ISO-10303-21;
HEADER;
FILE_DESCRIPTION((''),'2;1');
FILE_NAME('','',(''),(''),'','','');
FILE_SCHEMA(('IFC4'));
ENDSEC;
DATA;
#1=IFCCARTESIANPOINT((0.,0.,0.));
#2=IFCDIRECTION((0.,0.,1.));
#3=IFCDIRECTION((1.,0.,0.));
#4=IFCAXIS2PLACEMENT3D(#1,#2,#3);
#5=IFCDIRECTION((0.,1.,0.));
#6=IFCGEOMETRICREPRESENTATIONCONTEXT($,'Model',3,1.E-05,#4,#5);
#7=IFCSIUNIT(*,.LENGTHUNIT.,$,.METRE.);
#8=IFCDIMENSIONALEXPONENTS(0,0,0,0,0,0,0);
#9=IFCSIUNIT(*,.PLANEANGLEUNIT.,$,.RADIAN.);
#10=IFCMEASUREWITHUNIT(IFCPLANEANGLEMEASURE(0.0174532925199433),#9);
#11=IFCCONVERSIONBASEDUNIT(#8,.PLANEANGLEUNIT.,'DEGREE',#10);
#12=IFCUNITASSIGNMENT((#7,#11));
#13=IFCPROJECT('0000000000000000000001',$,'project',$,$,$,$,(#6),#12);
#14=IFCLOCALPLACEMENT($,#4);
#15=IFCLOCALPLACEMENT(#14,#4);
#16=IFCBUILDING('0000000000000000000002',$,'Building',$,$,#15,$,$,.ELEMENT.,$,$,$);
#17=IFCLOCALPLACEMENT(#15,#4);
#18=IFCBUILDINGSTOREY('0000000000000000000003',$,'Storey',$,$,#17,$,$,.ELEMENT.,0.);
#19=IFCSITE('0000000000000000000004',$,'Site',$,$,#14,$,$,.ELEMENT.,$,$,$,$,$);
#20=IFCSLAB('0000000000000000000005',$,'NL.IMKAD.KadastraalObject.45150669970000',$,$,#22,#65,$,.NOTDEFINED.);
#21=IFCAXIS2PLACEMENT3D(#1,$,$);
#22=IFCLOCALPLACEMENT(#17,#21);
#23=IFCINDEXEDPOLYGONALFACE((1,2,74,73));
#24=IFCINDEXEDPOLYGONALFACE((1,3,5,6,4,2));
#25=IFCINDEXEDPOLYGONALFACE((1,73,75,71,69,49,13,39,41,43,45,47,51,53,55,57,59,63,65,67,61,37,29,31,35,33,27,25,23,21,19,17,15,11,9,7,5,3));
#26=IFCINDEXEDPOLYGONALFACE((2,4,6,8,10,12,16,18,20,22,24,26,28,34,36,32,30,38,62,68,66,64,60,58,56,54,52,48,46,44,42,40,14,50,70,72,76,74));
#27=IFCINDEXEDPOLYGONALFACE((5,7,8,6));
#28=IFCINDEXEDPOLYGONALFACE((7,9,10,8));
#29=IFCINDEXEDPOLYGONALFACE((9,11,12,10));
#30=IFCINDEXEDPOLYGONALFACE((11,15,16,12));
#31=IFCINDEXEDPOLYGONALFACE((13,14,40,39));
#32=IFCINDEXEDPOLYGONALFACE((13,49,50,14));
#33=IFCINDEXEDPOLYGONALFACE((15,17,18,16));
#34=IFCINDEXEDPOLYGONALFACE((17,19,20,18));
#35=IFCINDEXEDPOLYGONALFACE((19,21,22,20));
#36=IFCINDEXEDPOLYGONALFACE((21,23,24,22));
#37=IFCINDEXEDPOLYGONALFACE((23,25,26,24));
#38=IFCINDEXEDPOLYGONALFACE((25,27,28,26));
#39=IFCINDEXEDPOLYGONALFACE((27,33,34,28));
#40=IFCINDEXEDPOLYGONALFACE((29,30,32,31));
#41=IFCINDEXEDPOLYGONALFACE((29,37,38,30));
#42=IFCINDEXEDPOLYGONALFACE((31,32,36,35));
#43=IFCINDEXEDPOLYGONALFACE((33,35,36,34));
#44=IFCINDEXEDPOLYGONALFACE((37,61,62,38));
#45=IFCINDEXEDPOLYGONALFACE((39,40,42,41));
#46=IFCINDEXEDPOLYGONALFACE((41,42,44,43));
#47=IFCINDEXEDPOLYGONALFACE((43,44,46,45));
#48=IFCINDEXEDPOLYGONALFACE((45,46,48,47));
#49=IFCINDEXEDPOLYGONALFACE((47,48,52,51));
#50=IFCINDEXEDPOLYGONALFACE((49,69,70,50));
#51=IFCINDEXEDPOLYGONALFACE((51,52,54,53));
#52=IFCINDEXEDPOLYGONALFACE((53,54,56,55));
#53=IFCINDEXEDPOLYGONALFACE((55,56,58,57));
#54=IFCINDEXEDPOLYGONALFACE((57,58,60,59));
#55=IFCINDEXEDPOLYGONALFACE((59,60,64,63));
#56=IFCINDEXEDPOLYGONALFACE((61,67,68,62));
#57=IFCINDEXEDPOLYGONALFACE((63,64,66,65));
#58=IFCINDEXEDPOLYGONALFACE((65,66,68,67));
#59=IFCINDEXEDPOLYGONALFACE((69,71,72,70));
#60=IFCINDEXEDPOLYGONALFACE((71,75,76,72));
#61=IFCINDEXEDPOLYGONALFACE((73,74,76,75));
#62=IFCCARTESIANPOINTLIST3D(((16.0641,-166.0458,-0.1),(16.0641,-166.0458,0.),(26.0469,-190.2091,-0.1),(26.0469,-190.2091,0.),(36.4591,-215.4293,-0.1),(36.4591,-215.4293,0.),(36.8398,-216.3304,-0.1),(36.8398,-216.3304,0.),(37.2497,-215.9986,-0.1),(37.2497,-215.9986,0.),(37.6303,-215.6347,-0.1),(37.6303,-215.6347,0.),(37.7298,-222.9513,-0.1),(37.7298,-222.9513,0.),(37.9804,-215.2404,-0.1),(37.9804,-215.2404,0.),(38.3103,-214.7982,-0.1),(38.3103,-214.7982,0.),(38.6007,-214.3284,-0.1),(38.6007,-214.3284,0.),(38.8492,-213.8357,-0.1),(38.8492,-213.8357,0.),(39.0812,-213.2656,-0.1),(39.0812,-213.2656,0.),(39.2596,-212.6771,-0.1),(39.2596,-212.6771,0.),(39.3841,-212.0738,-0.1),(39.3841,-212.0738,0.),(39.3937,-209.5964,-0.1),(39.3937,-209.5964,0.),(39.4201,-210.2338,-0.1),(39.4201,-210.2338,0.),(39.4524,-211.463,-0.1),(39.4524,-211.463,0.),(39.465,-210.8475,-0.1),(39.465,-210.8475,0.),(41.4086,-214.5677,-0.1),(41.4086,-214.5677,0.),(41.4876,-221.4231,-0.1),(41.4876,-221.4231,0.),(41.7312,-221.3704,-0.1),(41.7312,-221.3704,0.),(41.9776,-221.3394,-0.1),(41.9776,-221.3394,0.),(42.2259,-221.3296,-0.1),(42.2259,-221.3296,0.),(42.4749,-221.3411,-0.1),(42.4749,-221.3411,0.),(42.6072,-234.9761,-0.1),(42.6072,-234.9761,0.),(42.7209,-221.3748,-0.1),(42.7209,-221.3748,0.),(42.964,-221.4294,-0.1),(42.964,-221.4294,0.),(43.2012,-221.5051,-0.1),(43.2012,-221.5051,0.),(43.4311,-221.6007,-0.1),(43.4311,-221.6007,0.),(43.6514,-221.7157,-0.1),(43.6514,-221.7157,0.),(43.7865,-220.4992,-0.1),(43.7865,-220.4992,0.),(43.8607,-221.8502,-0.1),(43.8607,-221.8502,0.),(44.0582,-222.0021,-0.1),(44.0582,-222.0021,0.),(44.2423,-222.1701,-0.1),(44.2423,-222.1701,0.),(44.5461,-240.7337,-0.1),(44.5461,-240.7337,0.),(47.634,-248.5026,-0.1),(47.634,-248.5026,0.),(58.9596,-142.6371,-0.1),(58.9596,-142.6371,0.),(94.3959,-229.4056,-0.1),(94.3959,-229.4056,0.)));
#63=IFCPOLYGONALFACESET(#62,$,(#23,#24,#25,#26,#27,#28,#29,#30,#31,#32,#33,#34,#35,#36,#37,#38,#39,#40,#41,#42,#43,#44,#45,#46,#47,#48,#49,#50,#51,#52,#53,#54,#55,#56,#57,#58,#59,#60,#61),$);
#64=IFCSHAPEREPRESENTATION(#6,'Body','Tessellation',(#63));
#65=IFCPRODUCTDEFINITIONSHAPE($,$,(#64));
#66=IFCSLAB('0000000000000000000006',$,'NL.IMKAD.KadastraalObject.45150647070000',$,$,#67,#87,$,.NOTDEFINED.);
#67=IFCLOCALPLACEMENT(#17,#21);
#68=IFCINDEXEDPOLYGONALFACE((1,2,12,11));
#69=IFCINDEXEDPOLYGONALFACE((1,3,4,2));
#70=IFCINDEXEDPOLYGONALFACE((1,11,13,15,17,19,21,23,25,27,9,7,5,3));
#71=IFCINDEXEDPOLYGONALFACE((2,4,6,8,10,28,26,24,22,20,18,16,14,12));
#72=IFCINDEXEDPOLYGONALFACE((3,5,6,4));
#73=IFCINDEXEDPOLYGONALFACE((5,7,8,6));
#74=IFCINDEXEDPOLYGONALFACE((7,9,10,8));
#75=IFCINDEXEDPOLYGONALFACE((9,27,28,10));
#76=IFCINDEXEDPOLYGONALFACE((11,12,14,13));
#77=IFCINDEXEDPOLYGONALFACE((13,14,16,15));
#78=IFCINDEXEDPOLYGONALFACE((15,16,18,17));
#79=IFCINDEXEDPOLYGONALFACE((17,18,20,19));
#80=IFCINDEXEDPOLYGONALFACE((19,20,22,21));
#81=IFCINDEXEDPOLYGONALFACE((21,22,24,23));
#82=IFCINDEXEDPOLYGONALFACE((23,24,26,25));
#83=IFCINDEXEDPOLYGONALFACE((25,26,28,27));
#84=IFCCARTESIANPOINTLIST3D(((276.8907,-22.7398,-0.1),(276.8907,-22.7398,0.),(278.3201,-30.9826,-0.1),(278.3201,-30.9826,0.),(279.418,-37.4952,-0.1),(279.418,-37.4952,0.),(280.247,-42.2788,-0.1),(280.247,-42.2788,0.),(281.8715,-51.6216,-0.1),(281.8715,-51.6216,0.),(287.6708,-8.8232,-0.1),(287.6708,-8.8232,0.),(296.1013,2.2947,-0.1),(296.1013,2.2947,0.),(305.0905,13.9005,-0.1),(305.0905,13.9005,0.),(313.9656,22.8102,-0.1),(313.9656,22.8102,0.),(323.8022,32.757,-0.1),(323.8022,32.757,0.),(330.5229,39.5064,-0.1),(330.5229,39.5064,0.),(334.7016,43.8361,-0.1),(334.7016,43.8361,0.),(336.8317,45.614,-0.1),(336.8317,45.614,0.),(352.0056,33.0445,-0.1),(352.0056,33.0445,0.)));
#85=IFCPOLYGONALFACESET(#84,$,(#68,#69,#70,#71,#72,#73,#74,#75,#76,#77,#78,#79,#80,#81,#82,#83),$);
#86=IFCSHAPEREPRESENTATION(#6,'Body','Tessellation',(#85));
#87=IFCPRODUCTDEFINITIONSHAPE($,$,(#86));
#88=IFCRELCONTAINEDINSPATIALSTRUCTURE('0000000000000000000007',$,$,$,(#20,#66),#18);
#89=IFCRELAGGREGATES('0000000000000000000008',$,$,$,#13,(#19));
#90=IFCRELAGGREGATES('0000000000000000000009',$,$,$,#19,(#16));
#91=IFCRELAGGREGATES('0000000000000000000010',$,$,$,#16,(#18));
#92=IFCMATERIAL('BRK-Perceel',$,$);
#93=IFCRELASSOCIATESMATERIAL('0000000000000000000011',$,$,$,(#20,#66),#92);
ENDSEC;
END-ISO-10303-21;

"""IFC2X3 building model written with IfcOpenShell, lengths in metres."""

from ifc_helpers import new_model, entity, si_unit, converted_unit, direction, frame, origin_with_axes, place, context, project, spatial, polyline, outline, extrude, material, element, save


model = new_model("IFC2X3")

# Units and contexts
model_context = context("Model", 3, precision=1e-05, world=origin_with_axes(), true_north=direction((0.0, 1.0, 0.0)))
ifc_project = project(units=[si_unit("LENGTHUNIT", "METRE"), converted_unit("PLANEANGLEUNIT", "DEGREE", entity("IfcPlaneAngleMeasure", 0.0174532925199433), si_unit("PLANEANGLEUNIT", "RADIAN"), dimensions=[0, 0, 0, 0, 0, 0, 0])], contexts=[model_context])

# Site, building, storey
site_placement = place(None, origin_with_axes())
site = spatial("IfcSite", under=ifc_project, at=site_placement, Name="Site", CompositionType="ELEMENT")
building_placement = place(site_placement, origin_with_axes())
building = spatial("IfcBuilding", under=site, at=building_placement, Name="Building", CompositionType="ELEMENT")
storey_placement = place(building_placement, origin_with_axes())
storey = spatial("IfcBuildingStorey", under=building, at=storey_placement, Name="Storey", CompositionType="ELEMENT", Elevation=0.0)

# Slabs
ifc_material = material(Name="BRK-Perceel")
slab_1_placement = place(storey_placement, frame((0.0, 0.0, -0.1), z_axis=(0.0, 0.0, 1.0), x_axis=(1.0, 0.0, 0.0)))
element("IfcSlab", 1, at=slab_1_placement, inside=storey, material=ifc_material, Name="NL.IMKAD.KadastraalObject.45150669970000", PredefinedType="NOTDEFINED", context=model_context, shape_type="SweptSolid", body=[
    extrude(outline(polyline([(42.6072, -234.9761), (37.7298, -222.9513), (41.4876, -221.4231), (41.7312, -221.3704), (41.9776, -221.3394), (42.2259, -221.3296), (42.4749, -221.3411), (42.7209, -221.3748), (42.964, -221.4294), (43.2012, -221.5051), (43.4311, -221.6007), (43.6514, -221.7157), (43.8607, -221.8502), (44.0582, -222.0021), (44.2423, -222.1701), (43.7865, -220.4992), (41.4086, -214.5677), (39.3937, -209.5964), (39.4201, -210.2338), (39.465, -210.8475), (39.4524, -211.463), (39.3841, -212.0738), (39.2596, -212.6771), (39.0812, -213.2656), (38.8492, -213.8357), (38.6007, -214.3284), (38.3103, -214.7982), (37.9804, -215.2404), (37.6303, -215.6347), (37.2497, -215.9986), (36.8398, -216.3304), (36.4591, -215.4293), (26.0469, -190.2091), (16.0641, -166.0458), (58.9596, -142.6371), (94.3959, -229.4056), (47.634, -248.5026), (44.5461, -240.7337), (42.6072, -234.9761)])), origin_with_axes(), (0.0, 0.0, 1.0), 0.1),
])
slab_2_placement = place(storey_placement, frame((0.0, 0.0, -0.1), z_axis=(0.0, 0.0, 1.0), x_axis=(1.0, 0.0, 0.0)))
element("IfcSlab", 2, at=slab_2_placement, inside=storey, material=ifc_material, Name="NL.IMKAD.KadastraalObject.45150647070000", PredefinedType="NOTDEFINED", context=model_context, shape_type="SweptSolid", body=[
    extrude(outline(polyline([(280.247, -42.2788), (279.418, -37.4952), (278.3201, -30.9826), (276.8907, -22.7398), (287.6708, -8.8232), (296.1013, 2.2947), (305.0905, 13.9005), (313.9656, 22.8102), (323.8022, 32.757), (330.5229, 39.5064), (334.7016, 43.8361), (336.8317, 45.614), (352.0056, 33.0445), (281.8715, -51.6216), (280.247, -42.2788)])), origin_with_axes(), (0.0, 0.0, 1.0), 0.1),
])

save(model, "model.ifc")
